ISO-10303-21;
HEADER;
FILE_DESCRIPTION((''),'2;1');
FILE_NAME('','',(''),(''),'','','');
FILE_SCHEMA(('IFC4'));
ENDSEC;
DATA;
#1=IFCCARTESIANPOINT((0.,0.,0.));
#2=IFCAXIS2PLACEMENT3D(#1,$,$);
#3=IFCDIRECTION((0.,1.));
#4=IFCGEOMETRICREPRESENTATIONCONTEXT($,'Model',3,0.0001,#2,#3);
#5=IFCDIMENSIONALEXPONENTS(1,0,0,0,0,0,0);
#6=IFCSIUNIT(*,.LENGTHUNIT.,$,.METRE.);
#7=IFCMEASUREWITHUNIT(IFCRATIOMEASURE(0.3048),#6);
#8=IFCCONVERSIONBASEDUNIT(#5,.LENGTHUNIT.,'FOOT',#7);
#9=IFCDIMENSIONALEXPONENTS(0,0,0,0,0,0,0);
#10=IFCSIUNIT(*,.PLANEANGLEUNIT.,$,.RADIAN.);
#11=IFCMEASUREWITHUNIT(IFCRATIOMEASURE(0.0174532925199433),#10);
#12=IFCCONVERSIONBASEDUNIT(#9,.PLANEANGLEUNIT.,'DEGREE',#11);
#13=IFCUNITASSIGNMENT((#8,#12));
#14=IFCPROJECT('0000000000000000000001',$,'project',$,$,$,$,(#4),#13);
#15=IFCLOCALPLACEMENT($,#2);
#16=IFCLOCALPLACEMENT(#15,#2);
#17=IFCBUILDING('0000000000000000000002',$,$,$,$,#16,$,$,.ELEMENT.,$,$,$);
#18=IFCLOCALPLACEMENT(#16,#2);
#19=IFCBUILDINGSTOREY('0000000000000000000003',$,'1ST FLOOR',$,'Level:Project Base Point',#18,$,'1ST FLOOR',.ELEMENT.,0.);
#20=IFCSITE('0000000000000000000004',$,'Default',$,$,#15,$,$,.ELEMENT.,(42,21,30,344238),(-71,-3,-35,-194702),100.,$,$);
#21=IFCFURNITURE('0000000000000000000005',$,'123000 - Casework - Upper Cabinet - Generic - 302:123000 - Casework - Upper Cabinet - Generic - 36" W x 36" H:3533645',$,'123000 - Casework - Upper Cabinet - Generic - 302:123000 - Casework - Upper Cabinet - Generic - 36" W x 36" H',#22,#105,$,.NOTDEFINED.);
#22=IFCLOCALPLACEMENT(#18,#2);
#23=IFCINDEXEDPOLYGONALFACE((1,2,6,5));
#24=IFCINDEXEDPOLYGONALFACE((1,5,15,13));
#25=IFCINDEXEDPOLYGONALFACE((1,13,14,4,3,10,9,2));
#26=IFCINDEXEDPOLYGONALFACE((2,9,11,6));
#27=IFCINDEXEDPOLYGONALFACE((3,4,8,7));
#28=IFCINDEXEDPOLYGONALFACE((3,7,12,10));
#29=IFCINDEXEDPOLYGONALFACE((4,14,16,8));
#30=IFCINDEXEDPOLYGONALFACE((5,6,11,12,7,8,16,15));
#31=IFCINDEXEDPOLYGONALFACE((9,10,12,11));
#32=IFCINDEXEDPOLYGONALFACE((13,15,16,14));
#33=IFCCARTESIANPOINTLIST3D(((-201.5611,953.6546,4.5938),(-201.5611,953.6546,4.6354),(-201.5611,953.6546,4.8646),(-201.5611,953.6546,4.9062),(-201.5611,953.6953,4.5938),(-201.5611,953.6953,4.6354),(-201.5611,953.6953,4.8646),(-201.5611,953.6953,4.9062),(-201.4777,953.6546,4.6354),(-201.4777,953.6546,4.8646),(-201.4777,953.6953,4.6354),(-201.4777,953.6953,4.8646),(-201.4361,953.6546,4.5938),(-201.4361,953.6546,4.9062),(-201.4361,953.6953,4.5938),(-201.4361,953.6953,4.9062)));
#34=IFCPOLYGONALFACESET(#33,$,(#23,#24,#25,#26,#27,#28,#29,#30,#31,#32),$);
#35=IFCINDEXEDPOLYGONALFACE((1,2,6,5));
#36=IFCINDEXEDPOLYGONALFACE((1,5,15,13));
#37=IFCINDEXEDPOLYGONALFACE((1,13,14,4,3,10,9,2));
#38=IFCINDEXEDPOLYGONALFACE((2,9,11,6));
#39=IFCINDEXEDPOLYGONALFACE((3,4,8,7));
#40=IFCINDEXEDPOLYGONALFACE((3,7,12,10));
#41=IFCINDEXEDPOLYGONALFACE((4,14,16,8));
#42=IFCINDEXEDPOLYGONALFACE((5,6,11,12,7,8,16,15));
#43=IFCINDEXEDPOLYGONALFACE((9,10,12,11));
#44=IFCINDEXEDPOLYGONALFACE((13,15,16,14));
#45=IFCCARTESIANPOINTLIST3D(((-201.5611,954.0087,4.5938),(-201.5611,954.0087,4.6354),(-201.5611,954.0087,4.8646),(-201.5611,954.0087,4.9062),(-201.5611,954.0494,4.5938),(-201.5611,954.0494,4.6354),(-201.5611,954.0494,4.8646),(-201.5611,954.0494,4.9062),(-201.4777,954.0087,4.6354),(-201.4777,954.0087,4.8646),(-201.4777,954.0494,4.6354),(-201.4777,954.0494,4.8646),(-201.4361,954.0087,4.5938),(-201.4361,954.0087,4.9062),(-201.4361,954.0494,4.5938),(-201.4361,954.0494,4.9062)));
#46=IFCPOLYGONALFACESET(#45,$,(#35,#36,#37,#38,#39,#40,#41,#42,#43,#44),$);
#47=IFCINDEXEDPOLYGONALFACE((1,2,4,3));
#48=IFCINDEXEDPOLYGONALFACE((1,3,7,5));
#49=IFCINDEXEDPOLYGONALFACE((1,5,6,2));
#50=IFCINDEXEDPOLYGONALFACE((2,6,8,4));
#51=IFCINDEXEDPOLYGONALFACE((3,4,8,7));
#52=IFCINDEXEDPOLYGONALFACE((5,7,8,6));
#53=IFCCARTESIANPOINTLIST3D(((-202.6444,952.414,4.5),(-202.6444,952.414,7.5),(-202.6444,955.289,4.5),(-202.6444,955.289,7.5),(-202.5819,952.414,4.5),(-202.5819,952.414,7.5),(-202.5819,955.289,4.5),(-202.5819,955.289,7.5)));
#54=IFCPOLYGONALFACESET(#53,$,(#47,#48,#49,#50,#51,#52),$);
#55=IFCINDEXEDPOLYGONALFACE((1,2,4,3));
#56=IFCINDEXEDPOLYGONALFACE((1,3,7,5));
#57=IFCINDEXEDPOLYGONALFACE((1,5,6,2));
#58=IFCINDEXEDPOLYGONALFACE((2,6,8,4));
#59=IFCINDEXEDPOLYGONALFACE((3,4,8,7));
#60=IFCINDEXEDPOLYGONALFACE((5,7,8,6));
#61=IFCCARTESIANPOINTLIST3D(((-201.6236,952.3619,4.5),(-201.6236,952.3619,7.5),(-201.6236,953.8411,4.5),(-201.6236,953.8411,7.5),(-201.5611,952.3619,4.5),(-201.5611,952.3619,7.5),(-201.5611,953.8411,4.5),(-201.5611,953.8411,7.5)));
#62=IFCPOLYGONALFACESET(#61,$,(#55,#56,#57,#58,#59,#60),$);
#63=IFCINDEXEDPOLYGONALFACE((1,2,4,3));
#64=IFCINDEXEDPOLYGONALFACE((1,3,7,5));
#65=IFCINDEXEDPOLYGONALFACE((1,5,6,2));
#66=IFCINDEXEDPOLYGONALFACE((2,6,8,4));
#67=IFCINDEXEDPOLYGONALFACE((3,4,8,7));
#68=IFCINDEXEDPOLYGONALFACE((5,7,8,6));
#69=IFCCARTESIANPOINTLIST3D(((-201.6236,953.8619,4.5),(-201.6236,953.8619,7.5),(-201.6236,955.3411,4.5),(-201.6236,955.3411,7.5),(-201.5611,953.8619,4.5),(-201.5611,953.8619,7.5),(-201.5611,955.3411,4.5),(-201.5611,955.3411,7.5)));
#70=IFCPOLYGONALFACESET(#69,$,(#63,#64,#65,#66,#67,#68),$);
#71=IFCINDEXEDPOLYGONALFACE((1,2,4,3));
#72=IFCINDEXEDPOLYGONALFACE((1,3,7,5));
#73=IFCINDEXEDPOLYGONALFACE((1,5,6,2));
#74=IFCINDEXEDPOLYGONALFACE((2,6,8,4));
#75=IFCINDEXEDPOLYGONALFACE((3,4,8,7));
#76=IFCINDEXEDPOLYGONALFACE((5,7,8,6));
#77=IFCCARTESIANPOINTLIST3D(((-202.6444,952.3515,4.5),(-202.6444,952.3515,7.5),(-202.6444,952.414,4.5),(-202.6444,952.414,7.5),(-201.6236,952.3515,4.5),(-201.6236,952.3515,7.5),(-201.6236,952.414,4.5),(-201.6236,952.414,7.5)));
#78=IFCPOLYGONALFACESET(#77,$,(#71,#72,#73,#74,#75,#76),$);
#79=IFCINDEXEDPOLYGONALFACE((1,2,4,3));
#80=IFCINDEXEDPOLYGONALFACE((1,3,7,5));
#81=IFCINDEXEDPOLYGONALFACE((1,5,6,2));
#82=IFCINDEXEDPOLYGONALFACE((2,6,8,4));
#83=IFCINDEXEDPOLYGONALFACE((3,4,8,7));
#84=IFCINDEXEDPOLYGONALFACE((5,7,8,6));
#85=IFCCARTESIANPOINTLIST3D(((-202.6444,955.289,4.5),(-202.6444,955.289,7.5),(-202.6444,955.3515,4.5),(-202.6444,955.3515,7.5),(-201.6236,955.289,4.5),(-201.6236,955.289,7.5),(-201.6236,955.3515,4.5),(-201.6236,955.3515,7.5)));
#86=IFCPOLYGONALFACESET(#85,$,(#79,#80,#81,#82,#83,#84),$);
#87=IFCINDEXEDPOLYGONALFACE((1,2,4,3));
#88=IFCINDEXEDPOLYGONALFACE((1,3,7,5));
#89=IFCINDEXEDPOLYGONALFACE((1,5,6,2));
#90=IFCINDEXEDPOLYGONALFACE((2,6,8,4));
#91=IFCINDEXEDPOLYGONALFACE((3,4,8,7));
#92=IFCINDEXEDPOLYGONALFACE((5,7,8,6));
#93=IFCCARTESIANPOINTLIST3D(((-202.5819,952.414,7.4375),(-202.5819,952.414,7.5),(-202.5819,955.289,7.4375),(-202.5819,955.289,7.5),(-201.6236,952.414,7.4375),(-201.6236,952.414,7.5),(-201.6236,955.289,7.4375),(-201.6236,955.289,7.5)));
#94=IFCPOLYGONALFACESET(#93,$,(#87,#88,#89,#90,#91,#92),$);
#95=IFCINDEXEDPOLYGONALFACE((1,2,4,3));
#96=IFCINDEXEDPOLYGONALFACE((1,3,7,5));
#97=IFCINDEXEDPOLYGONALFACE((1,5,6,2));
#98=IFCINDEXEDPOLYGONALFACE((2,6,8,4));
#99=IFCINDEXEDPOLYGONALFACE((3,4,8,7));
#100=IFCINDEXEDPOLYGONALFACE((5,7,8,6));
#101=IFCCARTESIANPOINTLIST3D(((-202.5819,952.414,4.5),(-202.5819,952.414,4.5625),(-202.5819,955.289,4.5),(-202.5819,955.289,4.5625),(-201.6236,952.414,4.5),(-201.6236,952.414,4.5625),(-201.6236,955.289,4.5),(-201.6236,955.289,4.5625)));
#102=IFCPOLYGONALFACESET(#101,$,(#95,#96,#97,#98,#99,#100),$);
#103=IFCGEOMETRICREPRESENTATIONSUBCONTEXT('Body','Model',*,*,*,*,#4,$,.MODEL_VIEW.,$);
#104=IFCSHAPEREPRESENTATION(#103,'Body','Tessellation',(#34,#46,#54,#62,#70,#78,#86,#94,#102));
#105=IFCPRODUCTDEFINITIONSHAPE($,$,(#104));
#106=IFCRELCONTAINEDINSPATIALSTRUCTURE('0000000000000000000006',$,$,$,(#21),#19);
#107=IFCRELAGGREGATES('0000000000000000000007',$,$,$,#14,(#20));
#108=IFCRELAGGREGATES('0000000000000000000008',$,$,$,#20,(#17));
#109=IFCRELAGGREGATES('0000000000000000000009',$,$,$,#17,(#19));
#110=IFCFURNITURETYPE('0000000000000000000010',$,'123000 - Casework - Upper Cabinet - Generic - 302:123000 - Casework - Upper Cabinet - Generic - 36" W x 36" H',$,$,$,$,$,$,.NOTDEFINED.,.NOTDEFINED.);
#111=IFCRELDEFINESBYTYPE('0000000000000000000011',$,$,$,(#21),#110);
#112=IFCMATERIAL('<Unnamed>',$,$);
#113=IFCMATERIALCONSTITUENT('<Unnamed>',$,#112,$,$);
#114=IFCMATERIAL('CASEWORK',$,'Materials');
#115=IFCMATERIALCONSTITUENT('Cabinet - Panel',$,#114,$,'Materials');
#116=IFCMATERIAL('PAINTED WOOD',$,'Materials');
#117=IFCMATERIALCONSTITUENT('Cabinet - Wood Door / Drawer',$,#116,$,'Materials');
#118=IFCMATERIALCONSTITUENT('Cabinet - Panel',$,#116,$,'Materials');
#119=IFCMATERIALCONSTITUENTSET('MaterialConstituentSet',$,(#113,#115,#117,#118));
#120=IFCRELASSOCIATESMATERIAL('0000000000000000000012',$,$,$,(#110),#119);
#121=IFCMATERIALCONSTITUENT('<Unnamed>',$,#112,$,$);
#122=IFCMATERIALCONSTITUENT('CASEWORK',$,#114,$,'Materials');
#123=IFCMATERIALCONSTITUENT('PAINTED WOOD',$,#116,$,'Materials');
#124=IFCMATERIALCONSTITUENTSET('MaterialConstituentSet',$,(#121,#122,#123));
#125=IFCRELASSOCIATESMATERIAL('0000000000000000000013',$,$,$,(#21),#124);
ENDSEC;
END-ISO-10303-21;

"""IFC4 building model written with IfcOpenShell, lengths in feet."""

from ifc_helpers import new_model, entity, si_unit, converted_unit, direction, frame, frame_2d, origin, origin_2d_with_axis, place, context, subcontext, project, spatial, polyline, rectangle, outline, extrude, source, transform, mapped, material, constituent, constituent_set, type_object, type_shapes, element, save


model = new_model("IFC4")

# Units and contexts
model_context = context("Model", 3, precision=0.0001, world=origin(), true_north=direction((0.0, 1.0)))
body_context = subcontext(model_context, "Body", "Model", "MODEL_VIEW")
ifc_project = project(units=[converted_unit("LENGTHUNIT", "FOOT", entity("IfcRatioMeasure", 0.3048), si_unit("LENGTHUNIT", "METRE"), dimensions=[1, 0, 0, 0, 0, 0, 0]), converted_unit("PLANEANGLEUNIT", "DEGREE", entity("IfcRatioMeasure", 0.0174532925199433), si_unit("PLANEANGLEUNIT", "RADIAN"), dimensions=[0, 0, 0, 0, 0, 0, 0])], contexts=[model_context])

# Site, building, storey
site_placement = place(None, origin())
site = spatial("IfcSite", under=ifc_project, at=site_placement, Name="Default", CompositionType="ELEMENT", RefLatitude=(42, 21, 30, 344238), RefLongitude=(-71, -3, -35, -194702), RefElevation=100.0)
building_placement = place(site_placement, origin())
building = spatial("IfcBuilding", under=site, at=building_placement, CompositionType="ELEMENT")
storey_placement = place(building_placement, origin())
storey = spatial("IfcBuildingStorey", under=building, at=storey_placement, Name="1ST FLOOR", ObjectType="Level:Project Base Point", LongName="1ST FLOOR", CompositionType="ELEMENT", Elevation=0.0)

# Shared definitions
ifc_material_1 = material(Name="<Unnamed>")

# Shared definitions
ifc_material_2 = material(Name="PAINTED WOOD", Category="Materials")
ifc_material_3 = material(Name="CASEWORK", Category="Materials")

# Furniture
ifc_constituent_1 = constituent(ifc_material_1, Name="<Unnamed>")
ifc_constituent_2 = constituent(ifc_material_3, Name="CASEWORK", Category="Materials")
ifc_constituent_3 = constituent(ifc_material_2, Name="PAINTED WOOD", Category="Materials")
ifc_constituent_set_1 = constituent_set(constituents=[ifc_constituent_1, ifc_constituent_2, ifc_constituent_3], Name="MaterialConstituentSet")
ifc_constituent_4 = constituent(ifc_material_1, Name="<Unnamed>")
ifc_constituent_5 = constituent(ifc_material_3, Name="Cabinet - Panel", Category="Materials")
ifc_constituent_6 = constituent(ifc_material_2, Name="Cabinet - Wood Door / Drawer", Category="Materials")
ifc_constituent_7 = constituent(ifc_material_2, Name="Cabinet - Panel", Category="Materials")
ifc_constituent_set_2 = constituent_set(constituents=[ifc_constituent_4, ifc_constituent_5, ifc_constituent_6, ifc_constituent_7], Name="MaterialConstituentSet")
furniture_type_1 = type_object("IfcFurnitureType", Name="123000 - Casework - Upper Cabinet - Generic - 302:123000 - Casework - Upper Cabinet - Generic - 36\" W x 36\" H", AssemblyPlace="NOTDEFINED", PredefinedType="NOTDEFINED", material=ifc_constituent_set_2)
shared_shape_1 = source(origin(), body_context, "Body", "SweptSolid", [
    extrude(outline(polyline([(0.1146, -0.0521), (0.1562, -0.0521), (0.1562, 0.0729), (-0.1562, 0.0729), (-0.1562, -0.0521), (-0.1146, -0.0521), (-0.1146, 0.0313), (0.1146, 0.0313), (0.1146, -0.0521)])), frame((1.303, 0.0729, 0.25), z_axis=(1.0, 0.0, 0.0), x_axis=(0.0, 0.0, 1.0)), (0.0, 0.0, 1.0), 0.0407),
    extrude(outline(polyline([(0.1146, -0.0521), (0.1562, -0.0521), (0.1562, 0.0729), (-0.1562, 0.0729), (-0.1562, -0.0521), (-0.1146, -0.0521), (-0.1146, 0.0313), (0.1146, 0.0313), (0.1146, -0.0521)])), frame((1.6572, 0.0729, 0.25), z_axis=(1.0, 0.0, 0.0), x_axis=(0.0, 0.0, 1.0)), (0.0, 0.0, 1.0), 0.0407),
    extrude(rectangle(XDim=0.0625, YDim=2.875, at=origin_2d_with_axis()), frame((1.5, 1.177, 0.0), z_axis=(0.0, 0.0, 1.0), x_axis=(0.0, 1.0, 0.0)), (0.0, 0.0, 1.0), 3.0),
    extrude(rectangle(XDim=0.0625, YDim=1.4792, at=frame_2d((0.0, 0.0), x_axis=(1.0, 0.0))), frame((0.75, 0.1562, 0.0), z_axis=(0.0, 0.0, 1.0), x_axis=(0.0, -1.0, 0.0)), (0.0, 0.0, 1.0), 3.0),
    extrude(rectangle(XDim=0.0625, YDim=1.4792, at=origin_2d_with_axis()), frame((2.25, 0.1562, 0.0), z_axis=(0.0, 0.0, 1.0), x_axis=(0.0, -1.0, 0.0)), (0.0, 0.0, 1.0), 3.0),
    extrude(rectangle(XDim=0.0625, YDim=1.0208, at=origin_2d_with_axis()), frame((0.0312, 0.6979, 0.0), z_axis=(0.0, 0.0, 1.0), x_axis=(-1.0, 0.0, 0.0)), (0.0, 0.0, 1.0), 3.0),
    extrude(rectangle(XDim=0.0625, YDim=1.0208, at=origin_2d_with_axis()), frame((2.9688, 0.6979, 0.0), z_axis=(0.0, 0.0, 1.0), x_axis=(-1.0, 0.0, 0.0)), (0.0, 0.0, 1.0), 3.0),
    extrude(rectangle(XDim=2.875, YDim=0.9583, at=frame_2d((0.0, 0.0), x_axis=(1.0, 0.0))), frame((1.5, 0.6666, 2.9375), z_axis=(0.0, 0.0, 1.0), x_axis=(-1.0, 0.0, 0.0)), (0.0, 0.0, 1.0), 0.0625),
    extrude(rectangle(XDim=2.875, YDim=0.9583, at=frame_2d((0.0, 0.0), x_axis=(1.0, 0.0))), frame((1.5, 0.6666, 0.0), z_axis=(0.0, 0.0, 1.0), x_axis=(-1.0, 0.0, 0.0)), (0.0, 0.0, 1.0), 0.0625),
])
type_shapes(furniture_type_1, [shared_shape_1])
furniture_1_placement = place(storey_placement, frame((-201.4361, 952.3515, 4.5), z_axis=(0.0, 0.0, 1.0), x_axis=(0.0, 1.0, 0.0)))
element("IfcFurniture", 1, at=furniture_1_placement, inside=storey, type_object=furniture_type_1, material=ifc_constituent_set_1, Name="123000 - Casework - Upper Cabinet - Generic - 302:123000 - Casework - Upper Cabinet - Generic - 36\" W x 36\" H:3533645", ObjectType="123000 - Casework - Upper Cabinet - Generic - 302:123000 - Casework - Upper Cabinet - Generic - 36\" W x 36\" H", PredefinedType="NOTDEFINED", context=body_context, shape_type="MappedRepresentation", body=[
    mapped(shared_shape_1, transform((0.0, 0.0, 0.0), scale=1.0)),
])

save(model, "model.ifc")
